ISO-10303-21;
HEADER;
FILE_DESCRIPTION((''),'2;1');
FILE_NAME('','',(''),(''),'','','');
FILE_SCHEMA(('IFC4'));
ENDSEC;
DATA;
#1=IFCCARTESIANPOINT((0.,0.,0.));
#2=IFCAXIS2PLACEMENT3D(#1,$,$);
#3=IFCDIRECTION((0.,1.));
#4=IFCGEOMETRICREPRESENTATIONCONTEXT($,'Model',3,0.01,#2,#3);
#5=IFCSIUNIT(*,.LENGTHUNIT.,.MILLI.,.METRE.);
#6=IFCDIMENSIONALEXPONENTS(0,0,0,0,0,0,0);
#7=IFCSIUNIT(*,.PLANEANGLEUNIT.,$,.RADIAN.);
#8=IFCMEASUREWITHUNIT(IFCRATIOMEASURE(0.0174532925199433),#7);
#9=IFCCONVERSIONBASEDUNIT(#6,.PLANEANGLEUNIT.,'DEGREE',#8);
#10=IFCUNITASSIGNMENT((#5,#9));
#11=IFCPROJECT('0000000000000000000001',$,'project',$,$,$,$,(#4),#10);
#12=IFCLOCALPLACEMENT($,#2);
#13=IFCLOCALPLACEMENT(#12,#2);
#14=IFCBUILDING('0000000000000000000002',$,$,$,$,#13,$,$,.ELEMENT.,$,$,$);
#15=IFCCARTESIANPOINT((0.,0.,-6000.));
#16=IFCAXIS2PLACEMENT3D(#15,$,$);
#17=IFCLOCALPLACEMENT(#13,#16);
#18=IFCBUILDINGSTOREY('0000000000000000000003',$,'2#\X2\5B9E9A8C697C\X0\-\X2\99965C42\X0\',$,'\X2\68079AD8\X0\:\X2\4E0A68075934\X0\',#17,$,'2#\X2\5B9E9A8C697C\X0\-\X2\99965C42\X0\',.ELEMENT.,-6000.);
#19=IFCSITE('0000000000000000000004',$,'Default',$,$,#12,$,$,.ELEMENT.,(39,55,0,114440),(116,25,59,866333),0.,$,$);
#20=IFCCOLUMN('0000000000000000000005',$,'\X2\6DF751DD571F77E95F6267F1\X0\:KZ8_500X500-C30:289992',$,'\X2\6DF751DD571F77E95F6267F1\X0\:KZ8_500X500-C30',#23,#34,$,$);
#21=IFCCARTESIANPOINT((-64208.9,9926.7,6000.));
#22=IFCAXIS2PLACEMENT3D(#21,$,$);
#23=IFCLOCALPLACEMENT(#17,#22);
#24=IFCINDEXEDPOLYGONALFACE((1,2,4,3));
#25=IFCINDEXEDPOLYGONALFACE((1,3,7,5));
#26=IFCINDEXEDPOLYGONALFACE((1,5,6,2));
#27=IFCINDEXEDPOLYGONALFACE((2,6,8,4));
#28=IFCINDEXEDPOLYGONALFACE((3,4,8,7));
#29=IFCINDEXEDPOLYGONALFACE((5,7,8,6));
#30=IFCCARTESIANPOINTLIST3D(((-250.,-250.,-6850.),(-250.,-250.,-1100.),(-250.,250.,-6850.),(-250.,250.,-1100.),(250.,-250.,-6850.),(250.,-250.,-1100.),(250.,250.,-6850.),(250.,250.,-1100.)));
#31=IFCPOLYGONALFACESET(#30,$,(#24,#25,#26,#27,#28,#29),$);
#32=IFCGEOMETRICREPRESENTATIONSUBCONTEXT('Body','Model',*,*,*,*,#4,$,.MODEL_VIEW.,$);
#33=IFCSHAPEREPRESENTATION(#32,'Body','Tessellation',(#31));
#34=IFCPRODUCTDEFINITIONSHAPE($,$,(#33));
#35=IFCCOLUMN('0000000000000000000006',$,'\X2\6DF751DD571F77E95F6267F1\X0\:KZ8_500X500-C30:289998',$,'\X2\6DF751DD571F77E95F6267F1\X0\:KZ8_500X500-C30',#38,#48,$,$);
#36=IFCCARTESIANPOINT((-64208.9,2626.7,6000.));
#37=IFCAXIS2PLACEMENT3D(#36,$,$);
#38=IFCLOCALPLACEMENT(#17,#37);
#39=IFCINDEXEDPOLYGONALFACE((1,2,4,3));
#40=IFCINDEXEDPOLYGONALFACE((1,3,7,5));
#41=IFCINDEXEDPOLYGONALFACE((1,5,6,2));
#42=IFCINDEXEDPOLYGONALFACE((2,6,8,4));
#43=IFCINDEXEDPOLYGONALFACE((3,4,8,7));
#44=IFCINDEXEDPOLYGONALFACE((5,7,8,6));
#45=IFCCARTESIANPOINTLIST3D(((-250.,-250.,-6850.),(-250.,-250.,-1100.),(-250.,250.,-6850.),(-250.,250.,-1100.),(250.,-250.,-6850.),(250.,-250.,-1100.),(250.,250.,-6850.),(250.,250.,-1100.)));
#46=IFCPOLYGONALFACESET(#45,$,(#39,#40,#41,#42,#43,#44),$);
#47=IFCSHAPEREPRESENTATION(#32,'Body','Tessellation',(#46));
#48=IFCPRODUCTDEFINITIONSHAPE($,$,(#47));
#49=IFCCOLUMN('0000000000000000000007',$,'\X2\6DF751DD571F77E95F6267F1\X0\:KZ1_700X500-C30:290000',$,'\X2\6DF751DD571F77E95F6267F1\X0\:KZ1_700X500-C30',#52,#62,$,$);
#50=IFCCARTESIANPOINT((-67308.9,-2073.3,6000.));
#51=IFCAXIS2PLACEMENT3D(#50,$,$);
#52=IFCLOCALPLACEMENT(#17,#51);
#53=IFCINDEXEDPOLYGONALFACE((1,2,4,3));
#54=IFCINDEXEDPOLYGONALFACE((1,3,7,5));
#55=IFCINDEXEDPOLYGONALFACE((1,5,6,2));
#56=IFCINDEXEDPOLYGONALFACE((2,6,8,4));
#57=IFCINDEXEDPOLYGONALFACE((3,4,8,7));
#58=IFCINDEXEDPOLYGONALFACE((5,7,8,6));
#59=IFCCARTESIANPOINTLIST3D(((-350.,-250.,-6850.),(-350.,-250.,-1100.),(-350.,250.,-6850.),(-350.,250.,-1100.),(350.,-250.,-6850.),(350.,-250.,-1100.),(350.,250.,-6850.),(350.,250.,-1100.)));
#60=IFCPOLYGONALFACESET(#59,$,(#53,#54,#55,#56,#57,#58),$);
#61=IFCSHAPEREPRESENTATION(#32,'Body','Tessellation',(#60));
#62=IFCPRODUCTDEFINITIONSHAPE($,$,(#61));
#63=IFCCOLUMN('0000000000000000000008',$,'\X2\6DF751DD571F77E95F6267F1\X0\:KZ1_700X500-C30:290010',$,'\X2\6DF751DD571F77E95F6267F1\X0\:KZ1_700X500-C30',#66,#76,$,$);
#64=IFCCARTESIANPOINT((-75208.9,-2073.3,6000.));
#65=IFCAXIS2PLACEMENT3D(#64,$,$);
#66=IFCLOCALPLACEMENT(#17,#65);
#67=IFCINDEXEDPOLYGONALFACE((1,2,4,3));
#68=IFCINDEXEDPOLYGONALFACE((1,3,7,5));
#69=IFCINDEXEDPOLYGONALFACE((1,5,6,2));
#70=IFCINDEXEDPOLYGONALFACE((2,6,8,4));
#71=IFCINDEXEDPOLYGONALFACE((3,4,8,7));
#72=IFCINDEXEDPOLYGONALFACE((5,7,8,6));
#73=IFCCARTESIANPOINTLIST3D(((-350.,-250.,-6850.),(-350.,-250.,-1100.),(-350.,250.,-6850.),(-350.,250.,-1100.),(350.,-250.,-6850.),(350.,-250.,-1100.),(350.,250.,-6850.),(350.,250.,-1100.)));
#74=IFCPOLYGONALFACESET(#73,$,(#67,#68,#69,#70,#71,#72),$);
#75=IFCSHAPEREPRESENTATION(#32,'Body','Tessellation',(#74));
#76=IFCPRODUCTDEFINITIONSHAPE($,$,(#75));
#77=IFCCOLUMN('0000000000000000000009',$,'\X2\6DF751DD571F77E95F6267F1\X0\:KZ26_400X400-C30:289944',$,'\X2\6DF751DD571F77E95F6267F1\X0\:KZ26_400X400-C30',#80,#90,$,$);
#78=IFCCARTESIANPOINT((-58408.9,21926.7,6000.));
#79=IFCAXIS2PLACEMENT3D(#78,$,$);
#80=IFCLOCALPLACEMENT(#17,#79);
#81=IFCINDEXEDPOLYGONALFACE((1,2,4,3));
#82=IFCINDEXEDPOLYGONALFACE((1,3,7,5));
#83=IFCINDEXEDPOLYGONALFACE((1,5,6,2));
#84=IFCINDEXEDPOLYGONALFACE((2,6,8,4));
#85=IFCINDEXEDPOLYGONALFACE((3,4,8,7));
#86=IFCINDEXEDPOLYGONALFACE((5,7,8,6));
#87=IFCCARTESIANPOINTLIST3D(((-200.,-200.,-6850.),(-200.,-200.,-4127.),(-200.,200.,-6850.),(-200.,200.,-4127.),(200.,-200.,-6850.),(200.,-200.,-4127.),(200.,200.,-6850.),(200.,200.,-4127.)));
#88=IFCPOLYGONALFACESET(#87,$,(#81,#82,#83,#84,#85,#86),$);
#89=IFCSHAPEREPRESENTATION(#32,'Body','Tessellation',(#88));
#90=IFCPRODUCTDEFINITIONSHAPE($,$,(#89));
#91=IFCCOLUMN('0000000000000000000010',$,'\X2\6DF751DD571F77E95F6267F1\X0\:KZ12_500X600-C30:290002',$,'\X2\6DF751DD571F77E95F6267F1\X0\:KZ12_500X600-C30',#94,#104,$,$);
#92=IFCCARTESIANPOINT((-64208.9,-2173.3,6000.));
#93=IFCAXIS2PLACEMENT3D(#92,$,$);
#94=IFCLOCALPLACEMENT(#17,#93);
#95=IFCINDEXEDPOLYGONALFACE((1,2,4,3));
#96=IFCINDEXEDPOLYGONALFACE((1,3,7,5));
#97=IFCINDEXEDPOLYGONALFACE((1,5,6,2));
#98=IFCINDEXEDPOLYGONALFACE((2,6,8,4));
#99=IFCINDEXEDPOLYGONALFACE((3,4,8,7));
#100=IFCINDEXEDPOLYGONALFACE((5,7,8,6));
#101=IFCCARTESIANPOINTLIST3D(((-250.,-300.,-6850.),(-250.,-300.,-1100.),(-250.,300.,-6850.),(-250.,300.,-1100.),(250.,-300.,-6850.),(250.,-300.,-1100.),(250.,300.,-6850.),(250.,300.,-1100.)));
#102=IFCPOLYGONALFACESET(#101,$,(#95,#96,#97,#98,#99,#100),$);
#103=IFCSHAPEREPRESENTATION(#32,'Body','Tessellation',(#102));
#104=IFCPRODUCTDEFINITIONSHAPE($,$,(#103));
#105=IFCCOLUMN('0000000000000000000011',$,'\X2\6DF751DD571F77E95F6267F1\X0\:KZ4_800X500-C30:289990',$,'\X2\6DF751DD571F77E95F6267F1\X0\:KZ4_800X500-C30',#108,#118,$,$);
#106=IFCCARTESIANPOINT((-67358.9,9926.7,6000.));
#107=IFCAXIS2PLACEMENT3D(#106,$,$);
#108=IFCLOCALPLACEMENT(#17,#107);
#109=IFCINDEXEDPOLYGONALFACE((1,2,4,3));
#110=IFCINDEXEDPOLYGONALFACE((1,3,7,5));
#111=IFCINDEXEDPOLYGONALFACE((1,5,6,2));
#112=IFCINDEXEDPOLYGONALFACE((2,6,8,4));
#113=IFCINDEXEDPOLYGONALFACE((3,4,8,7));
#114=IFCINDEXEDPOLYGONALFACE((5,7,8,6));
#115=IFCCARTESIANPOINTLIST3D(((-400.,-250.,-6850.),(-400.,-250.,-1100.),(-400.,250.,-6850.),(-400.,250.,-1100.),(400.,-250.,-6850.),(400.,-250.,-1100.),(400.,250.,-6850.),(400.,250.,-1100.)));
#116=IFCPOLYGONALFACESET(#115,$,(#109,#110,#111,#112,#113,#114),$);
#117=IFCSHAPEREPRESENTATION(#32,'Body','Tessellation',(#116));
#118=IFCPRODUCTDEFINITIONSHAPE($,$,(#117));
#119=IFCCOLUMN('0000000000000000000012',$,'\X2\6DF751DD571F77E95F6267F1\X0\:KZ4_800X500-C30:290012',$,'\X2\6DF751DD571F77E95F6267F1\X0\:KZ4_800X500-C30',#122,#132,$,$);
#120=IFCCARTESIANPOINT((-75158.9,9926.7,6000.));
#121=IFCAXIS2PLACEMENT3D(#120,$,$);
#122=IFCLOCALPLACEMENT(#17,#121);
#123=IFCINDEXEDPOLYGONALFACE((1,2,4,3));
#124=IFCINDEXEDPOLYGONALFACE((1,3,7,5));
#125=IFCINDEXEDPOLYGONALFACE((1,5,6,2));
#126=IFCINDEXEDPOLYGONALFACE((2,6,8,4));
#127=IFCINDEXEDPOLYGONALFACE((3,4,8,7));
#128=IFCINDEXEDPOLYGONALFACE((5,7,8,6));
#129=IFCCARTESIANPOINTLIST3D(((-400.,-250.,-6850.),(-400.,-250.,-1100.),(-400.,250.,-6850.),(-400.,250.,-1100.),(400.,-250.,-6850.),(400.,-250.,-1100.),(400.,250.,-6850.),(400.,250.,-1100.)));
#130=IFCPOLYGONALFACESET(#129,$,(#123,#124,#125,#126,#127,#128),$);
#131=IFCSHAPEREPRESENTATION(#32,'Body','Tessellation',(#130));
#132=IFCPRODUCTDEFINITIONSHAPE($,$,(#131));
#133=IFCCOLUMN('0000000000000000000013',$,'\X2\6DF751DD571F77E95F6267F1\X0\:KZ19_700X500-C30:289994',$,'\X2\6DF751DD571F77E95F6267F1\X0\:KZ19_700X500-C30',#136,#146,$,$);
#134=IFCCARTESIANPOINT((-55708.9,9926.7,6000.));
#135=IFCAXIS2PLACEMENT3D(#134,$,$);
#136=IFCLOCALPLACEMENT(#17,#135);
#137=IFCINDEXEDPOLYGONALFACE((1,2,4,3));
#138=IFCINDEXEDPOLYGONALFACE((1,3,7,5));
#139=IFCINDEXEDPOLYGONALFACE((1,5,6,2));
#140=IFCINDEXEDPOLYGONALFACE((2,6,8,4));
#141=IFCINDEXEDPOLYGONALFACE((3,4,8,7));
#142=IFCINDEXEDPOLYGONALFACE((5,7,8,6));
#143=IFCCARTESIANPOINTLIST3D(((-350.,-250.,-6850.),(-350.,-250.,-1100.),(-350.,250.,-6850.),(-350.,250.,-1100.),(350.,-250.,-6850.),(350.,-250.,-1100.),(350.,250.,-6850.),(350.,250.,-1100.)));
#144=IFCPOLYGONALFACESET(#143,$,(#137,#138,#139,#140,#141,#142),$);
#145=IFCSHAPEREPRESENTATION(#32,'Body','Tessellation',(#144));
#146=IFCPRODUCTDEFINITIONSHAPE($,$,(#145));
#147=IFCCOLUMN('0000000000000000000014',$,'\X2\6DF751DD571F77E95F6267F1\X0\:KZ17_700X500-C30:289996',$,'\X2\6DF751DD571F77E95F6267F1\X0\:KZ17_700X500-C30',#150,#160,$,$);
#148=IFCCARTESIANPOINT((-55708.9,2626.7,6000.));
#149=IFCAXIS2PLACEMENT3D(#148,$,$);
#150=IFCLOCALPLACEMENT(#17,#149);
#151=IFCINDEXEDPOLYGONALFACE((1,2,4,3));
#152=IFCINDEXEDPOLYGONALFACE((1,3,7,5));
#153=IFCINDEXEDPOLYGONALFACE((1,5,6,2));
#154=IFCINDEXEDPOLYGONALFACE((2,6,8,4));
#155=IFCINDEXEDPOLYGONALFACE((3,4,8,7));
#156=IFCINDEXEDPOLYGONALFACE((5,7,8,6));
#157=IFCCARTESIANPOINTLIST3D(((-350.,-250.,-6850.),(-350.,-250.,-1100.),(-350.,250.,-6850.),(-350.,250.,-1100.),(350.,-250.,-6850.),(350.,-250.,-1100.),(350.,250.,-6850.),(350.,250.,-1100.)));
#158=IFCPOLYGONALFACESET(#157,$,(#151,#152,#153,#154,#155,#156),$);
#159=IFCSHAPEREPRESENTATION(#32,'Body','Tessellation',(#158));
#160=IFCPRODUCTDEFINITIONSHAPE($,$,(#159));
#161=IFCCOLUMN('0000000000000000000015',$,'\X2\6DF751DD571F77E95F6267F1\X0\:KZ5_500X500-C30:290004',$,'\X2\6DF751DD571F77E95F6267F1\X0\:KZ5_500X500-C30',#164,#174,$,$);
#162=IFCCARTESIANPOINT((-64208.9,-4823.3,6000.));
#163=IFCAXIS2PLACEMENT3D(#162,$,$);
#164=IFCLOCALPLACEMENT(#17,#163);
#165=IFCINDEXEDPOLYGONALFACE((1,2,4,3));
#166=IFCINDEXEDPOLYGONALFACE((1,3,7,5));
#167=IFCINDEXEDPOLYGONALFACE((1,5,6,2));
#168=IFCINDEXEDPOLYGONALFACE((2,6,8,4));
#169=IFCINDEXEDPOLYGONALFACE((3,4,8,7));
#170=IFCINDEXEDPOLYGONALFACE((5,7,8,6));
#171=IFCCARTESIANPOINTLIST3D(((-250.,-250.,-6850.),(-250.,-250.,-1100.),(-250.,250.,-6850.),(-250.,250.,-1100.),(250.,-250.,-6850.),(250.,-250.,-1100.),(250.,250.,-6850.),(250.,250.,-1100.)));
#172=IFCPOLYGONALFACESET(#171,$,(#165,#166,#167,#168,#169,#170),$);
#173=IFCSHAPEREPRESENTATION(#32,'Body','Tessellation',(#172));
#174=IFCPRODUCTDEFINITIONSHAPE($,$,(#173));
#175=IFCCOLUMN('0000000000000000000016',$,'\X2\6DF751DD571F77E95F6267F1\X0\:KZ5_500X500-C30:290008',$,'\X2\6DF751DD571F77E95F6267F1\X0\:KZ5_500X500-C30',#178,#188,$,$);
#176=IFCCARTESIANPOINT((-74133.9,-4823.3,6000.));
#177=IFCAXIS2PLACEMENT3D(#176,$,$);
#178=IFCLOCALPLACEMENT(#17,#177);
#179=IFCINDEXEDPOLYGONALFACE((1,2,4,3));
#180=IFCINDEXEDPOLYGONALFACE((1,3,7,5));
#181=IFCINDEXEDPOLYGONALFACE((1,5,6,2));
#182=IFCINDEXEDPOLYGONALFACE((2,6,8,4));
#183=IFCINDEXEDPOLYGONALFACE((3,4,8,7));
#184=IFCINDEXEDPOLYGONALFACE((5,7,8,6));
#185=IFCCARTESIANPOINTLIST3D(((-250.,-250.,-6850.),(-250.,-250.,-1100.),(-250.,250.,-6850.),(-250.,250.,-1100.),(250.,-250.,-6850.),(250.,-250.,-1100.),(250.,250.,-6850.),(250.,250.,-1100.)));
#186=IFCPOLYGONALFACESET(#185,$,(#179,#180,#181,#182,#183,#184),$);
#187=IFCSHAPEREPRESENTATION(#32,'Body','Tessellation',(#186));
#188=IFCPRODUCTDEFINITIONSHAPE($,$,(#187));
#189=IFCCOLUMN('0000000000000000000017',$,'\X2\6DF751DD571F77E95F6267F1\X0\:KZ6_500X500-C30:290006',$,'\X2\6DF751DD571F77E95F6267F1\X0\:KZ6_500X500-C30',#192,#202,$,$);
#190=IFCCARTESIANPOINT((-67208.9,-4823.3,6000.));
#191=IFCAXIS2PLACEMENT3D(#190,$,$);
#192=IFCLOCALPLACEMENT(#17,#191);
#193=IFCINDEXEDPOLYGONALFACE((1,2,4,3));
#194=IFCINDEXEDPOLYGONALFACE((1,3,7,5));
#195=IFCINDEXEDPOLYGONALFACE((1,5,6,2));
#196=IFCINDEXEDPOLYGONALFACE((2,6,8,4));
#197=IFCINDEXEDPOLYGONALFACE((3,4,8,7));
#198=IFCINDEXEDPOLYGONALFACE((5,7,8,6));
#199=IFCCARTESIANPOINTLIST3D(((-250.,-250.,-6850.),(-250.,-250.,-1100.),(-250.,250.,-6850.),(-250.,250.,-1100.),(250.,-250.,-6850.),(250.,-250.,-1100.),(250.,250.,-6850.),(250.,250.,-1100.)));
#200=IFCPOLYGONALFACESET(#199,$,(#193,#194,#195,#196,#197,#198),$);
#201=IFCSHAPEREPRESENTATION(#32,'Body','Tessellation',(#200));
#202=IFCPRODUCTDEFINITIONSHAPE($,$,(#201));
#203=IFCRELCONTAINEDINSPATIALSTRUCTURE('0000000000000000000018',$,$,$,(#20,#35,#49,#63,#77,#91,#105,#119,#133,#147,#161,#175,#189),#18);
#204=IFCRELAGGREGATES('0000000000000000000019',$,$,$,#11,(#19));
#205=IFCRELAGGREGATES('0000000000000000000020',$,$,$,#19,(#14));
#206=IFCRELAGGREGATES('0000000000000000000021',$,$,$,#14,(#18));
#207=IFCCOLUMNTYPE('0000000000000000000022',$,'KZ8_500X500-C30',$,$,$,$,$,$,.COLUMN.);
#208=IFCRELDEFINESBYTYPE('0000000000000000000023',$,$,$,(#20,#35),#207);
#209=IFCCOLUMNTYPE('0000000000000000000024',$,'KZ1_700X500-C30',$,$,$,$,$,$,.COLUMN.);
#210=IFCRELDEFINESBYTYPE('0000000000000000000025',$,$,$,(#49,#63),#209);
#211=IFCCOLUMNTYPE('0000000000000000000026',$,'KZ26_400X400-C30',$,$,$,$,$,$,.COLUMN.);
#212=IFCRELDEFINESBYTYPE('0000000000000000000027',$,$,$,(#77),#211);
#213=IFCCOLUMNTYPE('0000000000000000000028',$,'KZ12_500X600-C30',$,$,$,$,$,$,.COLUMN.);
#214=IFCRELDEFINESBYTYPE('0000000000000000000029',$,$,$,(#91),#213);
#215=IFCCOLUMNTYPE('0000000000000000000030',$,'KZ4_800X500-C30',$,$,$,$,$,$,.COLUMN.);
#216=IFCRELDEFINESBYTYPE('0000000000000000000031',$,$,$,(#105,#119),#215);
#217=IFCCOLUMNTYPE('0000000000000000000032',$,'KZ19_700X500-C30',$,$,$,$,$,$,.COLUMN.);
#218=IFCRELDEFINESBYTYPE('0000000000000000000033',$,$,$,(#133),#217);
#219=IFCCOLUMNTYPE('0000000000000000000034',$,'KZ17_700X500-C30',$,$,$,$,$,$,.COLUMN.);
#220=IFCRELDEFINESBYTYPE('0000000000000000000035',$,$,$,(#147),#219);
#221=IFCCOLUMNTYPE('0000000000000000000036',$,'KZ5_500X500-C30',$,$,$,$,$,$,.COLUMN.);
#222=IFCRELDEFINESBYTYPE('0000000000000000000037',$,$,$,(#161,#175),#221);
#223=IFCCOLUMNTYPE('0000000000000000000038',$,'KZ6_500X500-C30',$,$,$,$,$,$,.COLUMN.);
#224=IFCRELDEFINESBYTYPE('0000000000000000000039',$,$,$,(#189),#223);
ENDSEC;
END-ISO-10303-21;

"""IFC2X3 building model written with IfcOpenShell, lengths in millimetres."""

from ifc_helpers import new_model, entity, si_unit, converted_unit, direction, frame, origin, origin_2d_with_axis, place, context, subcontext, project, spatial, rectangle, extrude, source, transform, mapped, type_object, type_shapes, element, save


model = new_model("IFC2X3")

# Units and contexts
model_context = context("Model", 3, precision=0.01, world=origin(), true_north=direction((0.0, 1.0)))
body_context = subcontext(model_context, "Body", "Model", "MODEL_VIEW")
ifc_project = project(units=[si_unit("LENGTHUNIT", "METRE", prefix="MILLI"), converted_unit("PLANEANGLEUNIT", "DEGREE", entity("IfcRatioMeasure", 0.0174532925199433), si_unit("PLANEANGLEUNIT", "RADIAN"), dimensions=[0, 0, 0, 0, 0, 0, 0])], contexts=[model_context])

# Site, building, storey
site_placement = place(None, origin())
site = spatial("IfcSite", under=ifc_project, at=site_placement, Name="Default", CompositionType="ELEMENT", RefLatitude=(39, 55, 0, 114440), RefLongitude=(116, 25, 59, 866333), RefElevation=0.0)
building_placement = place(site_placement, origin())
building = spatial("IfcBuilding", under=site, at=building_placement, CompositionType="ELEMENT")
storey_placement = place(building_placement, frame((0.0, 0.0, -6000.0)))
storey = spatial("IfcBuildingStorey", under=building, at=storey_placement, Name="2#实验楼-首层", ObjectType="标高:上标头", LongName="2#实验楼-首层", CompositionType="ELEMENT", Elevation=-6000.0)

# Columns
column_type_1 = type_object("IfcColumnType", Name="KZ8_500X500-C30", PredefinedType="COLUMN")
shared_shape_1 = source(origin(), body_context, "Body", "SweptSolid", [
    extrude(rectangle(XDim=500.0, YDim=500.0, at=origin_2d_with_axis()), frame((0.0, 0.0, -6850.0), z_axis=(0.0, 0.0, 1.0), x_axis=(0.0, -1.0, 0.0)), (0.0, 0.0, 1.0), 5750.0),
])
type_shapes(column_type_1, [shared_shape_1])
for number, where, name in (
    (1, (-64208.9, 9926.7, 6000.0), "混凝土矩形柱:KZ8_500X500-C30:289992"),
    (2, (-64208.9, 2626.7, 6000.0), "混凝土矩形柱:KZ8_500X500-C30:289998"),
):
    element("IfcColumn", number, at=place(storey_placement, frame(where)), inside=storey, type_object=column_type_1, Name=name, ObjectType="混凝土矩形柱:KZ8_500X500-C30", context=body_context, shape_type="MappedRepresentation", body=[
        mapped(shared_shape_1, transform((0.0, 0.0, 0.0), scale=1.0)),
    ])
column_type_2 = type_object("IfcColumnType", Name="KZ1_700X500-C30", PredefinedType="COLUMN")
shared_shape_2 = source(origin(), body_context, "Body", "SweptSolid", [
    extrude(rectangle(XDim=500.0, YDim=700.0, at=origin_2d_with_axis()), frame((0.0, 0.0, -6850.0), z_axis=(0.0, 0.0, 1.0), x_axis=(0.0, -1.0, 0.0)), (0.0, 0.0, 1.0), 5750.0),
])
type_shapes(column_type_2, [shared_shape_2])
for number, where, name in (
    (3, (-67308.9, -2073.3, 6000.0), "混凝土矩形柱:KZ1_700X500-C30:290000"),
    (4, (-75208.9, -2073.3, 6000.0), "混凝土矩形柱:KZ1_700X500-C30:290010"),
):
    element("IfcColumn", number, at=place(storey_placement, frame(where)), inside=storey, type_object=column_type_2, Name=name, ObjectType="混凝土矩形柱:KZ1_700X500-C30", context=body_context, shape_type="MappedRepresentation", body=[
        mapped(shared_shape_2, transform((0.0, 0.0, 0.0), scale=1.0)),
    ])
column_type_3 = type_object("IfcColumnType", Name="KZ26_400X400-C30", PredefinedType="COLUMN")
shared_shape_3 = source(origin(), body_context, "Body", "SweptSolid", [
    extrude(rectangle(XDim=400.0, YDim=400.0, at=origin_2d_with_axis()), frame((0.0, 0.0, -6850.0), z_axis=(0.0, 0.0, 1.0), x_axis=(0.0, -1.0, 0.0)), (0.0, 0.0, 1.0), 2723.0),
])
type_shapes(column_type_3, [shared_shape_3])
column_1_placement = place(storey_placement, frame((-58408.9, 21926.7, 6000.0)))
element("IfcColumn", 5, at=column_1_placement, inside=storey, type_object=column_type_3, Name="混凝土矩形柱:KZ26_400X400-C30:289944", ObjectType="混凝土矩形柱:KZ26_400X400-C30", context=body_context, shape_type="MappedRepresentation", body=[
    mapped(shared_shape_3, transform((0.0, 0.0, 0.0), scale=1.0)),
])
column_type_4 = type_object("IfcColumnType", Name="KZ12_500X600-C30", PredefinedType="COLUMN")
shared_shape_4 = source(origin(), body_context, "Body", "SweptSolid", [
    extrude(rectangle(XDim=600.0, YDim=500.0, at=origin_2d_with_axis()), frame((0.0, 0.0, -6850.0), z_axis=(0.0, 0.0, 1.0), x_axis=(0.0, -1.0, 0.0)), (0.0, 0.0, 1.0), 5750.0),
])
type_shapes(column_type_4, [shared_shape_4])
column_2_placement = place(storey_placement, frame((-64208.9, -2173.3, 6000.0)))
element("IfcColumn", 6, at=column_2_placement, inside=storey, type_object=column_type_4, Name="混凝土矩形柱:KZ12_500X600-C30:290002", ObjectType="混凝土矩形柱:KZ12_500X600-C30", context=body_context, shape_type="MappedRepresentation", body=[
    mapped(shared_shape_4, transform((0.0, 0.0, 0.0), scale=1.0)),
])
column_type_5 = type_object("IfcColumnType", Name="KZ4_800X500-C30", PredefinedType="COLUMN")
shared_shape_5 = source(origin(), body_context, "Body", "SweptSolid", [
    extrude(rectangle(XDim=500.0, YDim=800.0, at=origin_2d_with_axis()), frame((0.0, 0.0, -6850.0), z_axis=(0.0, 0.0, 1.0), x_axis=(0.0, -1.0, 0.0)), (0.0, 0.0, 1.0), 5750.0),
])
type_shapes(column_type_5, [shared_shape_5])
for number, where, name in (
    (7, (-67358.9, 9926.7, 6000.0), "混凝土矩形柱:KZ4_800X500-C30:289990"),
    (8, (-75158.9, 9926.7, 6000.0), "混凝土矩形柱:KZ4_800X500-C30:290012"),
):
    element("IfcColumn", number, at=place(storey_placement, frame(where)), inside=storey, type_object=column_type_5, Name=name, ObjectType="混凝土矩形柱:KZ4_800X500-C30", context=body_context, shape_type="MappedRepresentation", body=[
        mapped(shared_shape_5, transform((0.0, 0.0, 0.0), scale=1.0)),
    ])
column_type_6 = type_object("IfcColumnType", Name="KZ19_700X500-C30", PredefinedType="COLUMN")
shared_shape_6 = source(origin(), body_context, "Body", "SweptSolid", [
    extrude(rectangle(XDim=500.0, YDim=700.0, at=origin_2d_with_axis()), frame((0.0, 0.0, -6850.0), z_axis=(0.0, 0.0, 1.0), x_axis=(0.0, -1.0, 0.0)), (0.0, 0.0, 1.0), 5750.0),
])
type_shapes(column_type_6, [shared_shape_6])
column_3_placement = place(storey_placement, frame((-55708.9, 9926.7, 6000.0)))
element("IfcColumn", 9, at=column_3_placement, inside=storey, type_object=column_type_6, Name="混凝土矩形柱:KZ19_700X500-C30:289994", ObjectType="混凝土矩形柱:KZ19_700X500-C30", context=body_context, shape_type="MappedRepresentation", body=[
    mapped(shared_shape_6, transform((0.0, 0.0, 0.0), scale=1.0)),
])
column_type_7 = type_object("IfcColumnType", Name="KZ17_700X500-C30", PredefinedType="COLUMN")
shared_shape_7 = source(origin(), body_context, "Body", "SweptSolid", [
    extrude(rectangle(XDim=500.0, YDim=700.0, at=origin_2d_with_axis()), frame((0.0, 0.0, -6850.0), z_axis=(0.0, 0.0, 1.0), x_axis=(0.0, -1.0, 0.0)), (0.0, 0.0, 1.0), 5750.0),
])
type_shapes(column_type_7, [shared_shape_7])
column_4_placement = place(storey_placement, frame((-55708.9, 2626.7, 6000.0)))
element("IfcColumn", 10, at=column_4_placement, inside=storey, type_object=column_type_7, Name="混凝土矩形柱:KZ17_700X500-C30:289996", ObjectType="混凝土矩形柱:KZ17_700X500-C30", context=body_context, shape_type="MappedRepresentation", body=[
    mapped(shared_shape_7, transform((0.0, 0.0, 0.0), scale=1.0)),
])
column_type_8 = type_object("IfcColumnType", Name="KZ5_500X500-C30", PredefinedType="COLUMN")
shared_shape_8 = source(origin(), body_context, "Body", "SweptSolid", [
    extrude(rectangle(XDim=500.0, YDim=500.0, at=origin_2d_with_axis()), frame((0.0, 0.0, -6850.0), z_axis=(0.0, 0.0, 1.0), x_axis=(0.0, -1.0, 0.0)), (0.0, 0.0, 1.0), 5750.0),
])
type_shapes(column_type_8, [shared_shape_8])
for number, where, name in (
    (11, (-64208.9, -4823.3, 6000.0), "混凝土矩形柱:KZ5_500X500-C30:290004"),
    (12, (-74133.9, -4823.3, 6000.0), "混凝土矩形柱:KZ5_500X500-C30:290008"),
):
    element("IfcColumn", number, at=place(storey_placement, frame(where)), inside=storey, type_object=column_type_8, Name=name, ObjectType="混凝土矩形柱:KZ5_500X500-C30", context=body_context, shape_type="MappedRepresentation", body=[
        mapped(shared_shape_8, transform((0.0, 0.0, 0.0), scale=1.0)),
    ])
column_type_9 = type_object("IfcColumnType", Name="KZ6_500X500-C30", PredefinedType="COLUMN")
shared_shape_9 = source(origin(), body_context, "Body", "SweptSolid", [
    extrude(rectangle(XDim=500.0, YDim=500.0, at=origin_2d_with_axis()), frame((0.0, 0.0, -6850.0), z_axis=(0.0, 0.0, 1.0), x_axis=(0.0, -1.0, 0.0)), (0.0, 0.0, 1.0), 5750.0),
])
type_shapes(column_type_9, [shared_shape_9])
column_5_placement = place(storey_placement, frame((-67208.9, -4823.3, 6000.0)))
element("IfcColumn", 13, at=column_5_placement, inside=storey, type_object=column_type_9, Name="混凝土矩形柱:KZ6_500X500-C30:290006", ObjectType="混凝土矩形柱:KZ6_500X500-C30", context=body_context, shape_type="MappedRepresentation", body=[
    mapped(shared_shape_9, transform((0.0, 0.0, 0.0), scale=1.0)),
])

save(model, "model.ifc")
